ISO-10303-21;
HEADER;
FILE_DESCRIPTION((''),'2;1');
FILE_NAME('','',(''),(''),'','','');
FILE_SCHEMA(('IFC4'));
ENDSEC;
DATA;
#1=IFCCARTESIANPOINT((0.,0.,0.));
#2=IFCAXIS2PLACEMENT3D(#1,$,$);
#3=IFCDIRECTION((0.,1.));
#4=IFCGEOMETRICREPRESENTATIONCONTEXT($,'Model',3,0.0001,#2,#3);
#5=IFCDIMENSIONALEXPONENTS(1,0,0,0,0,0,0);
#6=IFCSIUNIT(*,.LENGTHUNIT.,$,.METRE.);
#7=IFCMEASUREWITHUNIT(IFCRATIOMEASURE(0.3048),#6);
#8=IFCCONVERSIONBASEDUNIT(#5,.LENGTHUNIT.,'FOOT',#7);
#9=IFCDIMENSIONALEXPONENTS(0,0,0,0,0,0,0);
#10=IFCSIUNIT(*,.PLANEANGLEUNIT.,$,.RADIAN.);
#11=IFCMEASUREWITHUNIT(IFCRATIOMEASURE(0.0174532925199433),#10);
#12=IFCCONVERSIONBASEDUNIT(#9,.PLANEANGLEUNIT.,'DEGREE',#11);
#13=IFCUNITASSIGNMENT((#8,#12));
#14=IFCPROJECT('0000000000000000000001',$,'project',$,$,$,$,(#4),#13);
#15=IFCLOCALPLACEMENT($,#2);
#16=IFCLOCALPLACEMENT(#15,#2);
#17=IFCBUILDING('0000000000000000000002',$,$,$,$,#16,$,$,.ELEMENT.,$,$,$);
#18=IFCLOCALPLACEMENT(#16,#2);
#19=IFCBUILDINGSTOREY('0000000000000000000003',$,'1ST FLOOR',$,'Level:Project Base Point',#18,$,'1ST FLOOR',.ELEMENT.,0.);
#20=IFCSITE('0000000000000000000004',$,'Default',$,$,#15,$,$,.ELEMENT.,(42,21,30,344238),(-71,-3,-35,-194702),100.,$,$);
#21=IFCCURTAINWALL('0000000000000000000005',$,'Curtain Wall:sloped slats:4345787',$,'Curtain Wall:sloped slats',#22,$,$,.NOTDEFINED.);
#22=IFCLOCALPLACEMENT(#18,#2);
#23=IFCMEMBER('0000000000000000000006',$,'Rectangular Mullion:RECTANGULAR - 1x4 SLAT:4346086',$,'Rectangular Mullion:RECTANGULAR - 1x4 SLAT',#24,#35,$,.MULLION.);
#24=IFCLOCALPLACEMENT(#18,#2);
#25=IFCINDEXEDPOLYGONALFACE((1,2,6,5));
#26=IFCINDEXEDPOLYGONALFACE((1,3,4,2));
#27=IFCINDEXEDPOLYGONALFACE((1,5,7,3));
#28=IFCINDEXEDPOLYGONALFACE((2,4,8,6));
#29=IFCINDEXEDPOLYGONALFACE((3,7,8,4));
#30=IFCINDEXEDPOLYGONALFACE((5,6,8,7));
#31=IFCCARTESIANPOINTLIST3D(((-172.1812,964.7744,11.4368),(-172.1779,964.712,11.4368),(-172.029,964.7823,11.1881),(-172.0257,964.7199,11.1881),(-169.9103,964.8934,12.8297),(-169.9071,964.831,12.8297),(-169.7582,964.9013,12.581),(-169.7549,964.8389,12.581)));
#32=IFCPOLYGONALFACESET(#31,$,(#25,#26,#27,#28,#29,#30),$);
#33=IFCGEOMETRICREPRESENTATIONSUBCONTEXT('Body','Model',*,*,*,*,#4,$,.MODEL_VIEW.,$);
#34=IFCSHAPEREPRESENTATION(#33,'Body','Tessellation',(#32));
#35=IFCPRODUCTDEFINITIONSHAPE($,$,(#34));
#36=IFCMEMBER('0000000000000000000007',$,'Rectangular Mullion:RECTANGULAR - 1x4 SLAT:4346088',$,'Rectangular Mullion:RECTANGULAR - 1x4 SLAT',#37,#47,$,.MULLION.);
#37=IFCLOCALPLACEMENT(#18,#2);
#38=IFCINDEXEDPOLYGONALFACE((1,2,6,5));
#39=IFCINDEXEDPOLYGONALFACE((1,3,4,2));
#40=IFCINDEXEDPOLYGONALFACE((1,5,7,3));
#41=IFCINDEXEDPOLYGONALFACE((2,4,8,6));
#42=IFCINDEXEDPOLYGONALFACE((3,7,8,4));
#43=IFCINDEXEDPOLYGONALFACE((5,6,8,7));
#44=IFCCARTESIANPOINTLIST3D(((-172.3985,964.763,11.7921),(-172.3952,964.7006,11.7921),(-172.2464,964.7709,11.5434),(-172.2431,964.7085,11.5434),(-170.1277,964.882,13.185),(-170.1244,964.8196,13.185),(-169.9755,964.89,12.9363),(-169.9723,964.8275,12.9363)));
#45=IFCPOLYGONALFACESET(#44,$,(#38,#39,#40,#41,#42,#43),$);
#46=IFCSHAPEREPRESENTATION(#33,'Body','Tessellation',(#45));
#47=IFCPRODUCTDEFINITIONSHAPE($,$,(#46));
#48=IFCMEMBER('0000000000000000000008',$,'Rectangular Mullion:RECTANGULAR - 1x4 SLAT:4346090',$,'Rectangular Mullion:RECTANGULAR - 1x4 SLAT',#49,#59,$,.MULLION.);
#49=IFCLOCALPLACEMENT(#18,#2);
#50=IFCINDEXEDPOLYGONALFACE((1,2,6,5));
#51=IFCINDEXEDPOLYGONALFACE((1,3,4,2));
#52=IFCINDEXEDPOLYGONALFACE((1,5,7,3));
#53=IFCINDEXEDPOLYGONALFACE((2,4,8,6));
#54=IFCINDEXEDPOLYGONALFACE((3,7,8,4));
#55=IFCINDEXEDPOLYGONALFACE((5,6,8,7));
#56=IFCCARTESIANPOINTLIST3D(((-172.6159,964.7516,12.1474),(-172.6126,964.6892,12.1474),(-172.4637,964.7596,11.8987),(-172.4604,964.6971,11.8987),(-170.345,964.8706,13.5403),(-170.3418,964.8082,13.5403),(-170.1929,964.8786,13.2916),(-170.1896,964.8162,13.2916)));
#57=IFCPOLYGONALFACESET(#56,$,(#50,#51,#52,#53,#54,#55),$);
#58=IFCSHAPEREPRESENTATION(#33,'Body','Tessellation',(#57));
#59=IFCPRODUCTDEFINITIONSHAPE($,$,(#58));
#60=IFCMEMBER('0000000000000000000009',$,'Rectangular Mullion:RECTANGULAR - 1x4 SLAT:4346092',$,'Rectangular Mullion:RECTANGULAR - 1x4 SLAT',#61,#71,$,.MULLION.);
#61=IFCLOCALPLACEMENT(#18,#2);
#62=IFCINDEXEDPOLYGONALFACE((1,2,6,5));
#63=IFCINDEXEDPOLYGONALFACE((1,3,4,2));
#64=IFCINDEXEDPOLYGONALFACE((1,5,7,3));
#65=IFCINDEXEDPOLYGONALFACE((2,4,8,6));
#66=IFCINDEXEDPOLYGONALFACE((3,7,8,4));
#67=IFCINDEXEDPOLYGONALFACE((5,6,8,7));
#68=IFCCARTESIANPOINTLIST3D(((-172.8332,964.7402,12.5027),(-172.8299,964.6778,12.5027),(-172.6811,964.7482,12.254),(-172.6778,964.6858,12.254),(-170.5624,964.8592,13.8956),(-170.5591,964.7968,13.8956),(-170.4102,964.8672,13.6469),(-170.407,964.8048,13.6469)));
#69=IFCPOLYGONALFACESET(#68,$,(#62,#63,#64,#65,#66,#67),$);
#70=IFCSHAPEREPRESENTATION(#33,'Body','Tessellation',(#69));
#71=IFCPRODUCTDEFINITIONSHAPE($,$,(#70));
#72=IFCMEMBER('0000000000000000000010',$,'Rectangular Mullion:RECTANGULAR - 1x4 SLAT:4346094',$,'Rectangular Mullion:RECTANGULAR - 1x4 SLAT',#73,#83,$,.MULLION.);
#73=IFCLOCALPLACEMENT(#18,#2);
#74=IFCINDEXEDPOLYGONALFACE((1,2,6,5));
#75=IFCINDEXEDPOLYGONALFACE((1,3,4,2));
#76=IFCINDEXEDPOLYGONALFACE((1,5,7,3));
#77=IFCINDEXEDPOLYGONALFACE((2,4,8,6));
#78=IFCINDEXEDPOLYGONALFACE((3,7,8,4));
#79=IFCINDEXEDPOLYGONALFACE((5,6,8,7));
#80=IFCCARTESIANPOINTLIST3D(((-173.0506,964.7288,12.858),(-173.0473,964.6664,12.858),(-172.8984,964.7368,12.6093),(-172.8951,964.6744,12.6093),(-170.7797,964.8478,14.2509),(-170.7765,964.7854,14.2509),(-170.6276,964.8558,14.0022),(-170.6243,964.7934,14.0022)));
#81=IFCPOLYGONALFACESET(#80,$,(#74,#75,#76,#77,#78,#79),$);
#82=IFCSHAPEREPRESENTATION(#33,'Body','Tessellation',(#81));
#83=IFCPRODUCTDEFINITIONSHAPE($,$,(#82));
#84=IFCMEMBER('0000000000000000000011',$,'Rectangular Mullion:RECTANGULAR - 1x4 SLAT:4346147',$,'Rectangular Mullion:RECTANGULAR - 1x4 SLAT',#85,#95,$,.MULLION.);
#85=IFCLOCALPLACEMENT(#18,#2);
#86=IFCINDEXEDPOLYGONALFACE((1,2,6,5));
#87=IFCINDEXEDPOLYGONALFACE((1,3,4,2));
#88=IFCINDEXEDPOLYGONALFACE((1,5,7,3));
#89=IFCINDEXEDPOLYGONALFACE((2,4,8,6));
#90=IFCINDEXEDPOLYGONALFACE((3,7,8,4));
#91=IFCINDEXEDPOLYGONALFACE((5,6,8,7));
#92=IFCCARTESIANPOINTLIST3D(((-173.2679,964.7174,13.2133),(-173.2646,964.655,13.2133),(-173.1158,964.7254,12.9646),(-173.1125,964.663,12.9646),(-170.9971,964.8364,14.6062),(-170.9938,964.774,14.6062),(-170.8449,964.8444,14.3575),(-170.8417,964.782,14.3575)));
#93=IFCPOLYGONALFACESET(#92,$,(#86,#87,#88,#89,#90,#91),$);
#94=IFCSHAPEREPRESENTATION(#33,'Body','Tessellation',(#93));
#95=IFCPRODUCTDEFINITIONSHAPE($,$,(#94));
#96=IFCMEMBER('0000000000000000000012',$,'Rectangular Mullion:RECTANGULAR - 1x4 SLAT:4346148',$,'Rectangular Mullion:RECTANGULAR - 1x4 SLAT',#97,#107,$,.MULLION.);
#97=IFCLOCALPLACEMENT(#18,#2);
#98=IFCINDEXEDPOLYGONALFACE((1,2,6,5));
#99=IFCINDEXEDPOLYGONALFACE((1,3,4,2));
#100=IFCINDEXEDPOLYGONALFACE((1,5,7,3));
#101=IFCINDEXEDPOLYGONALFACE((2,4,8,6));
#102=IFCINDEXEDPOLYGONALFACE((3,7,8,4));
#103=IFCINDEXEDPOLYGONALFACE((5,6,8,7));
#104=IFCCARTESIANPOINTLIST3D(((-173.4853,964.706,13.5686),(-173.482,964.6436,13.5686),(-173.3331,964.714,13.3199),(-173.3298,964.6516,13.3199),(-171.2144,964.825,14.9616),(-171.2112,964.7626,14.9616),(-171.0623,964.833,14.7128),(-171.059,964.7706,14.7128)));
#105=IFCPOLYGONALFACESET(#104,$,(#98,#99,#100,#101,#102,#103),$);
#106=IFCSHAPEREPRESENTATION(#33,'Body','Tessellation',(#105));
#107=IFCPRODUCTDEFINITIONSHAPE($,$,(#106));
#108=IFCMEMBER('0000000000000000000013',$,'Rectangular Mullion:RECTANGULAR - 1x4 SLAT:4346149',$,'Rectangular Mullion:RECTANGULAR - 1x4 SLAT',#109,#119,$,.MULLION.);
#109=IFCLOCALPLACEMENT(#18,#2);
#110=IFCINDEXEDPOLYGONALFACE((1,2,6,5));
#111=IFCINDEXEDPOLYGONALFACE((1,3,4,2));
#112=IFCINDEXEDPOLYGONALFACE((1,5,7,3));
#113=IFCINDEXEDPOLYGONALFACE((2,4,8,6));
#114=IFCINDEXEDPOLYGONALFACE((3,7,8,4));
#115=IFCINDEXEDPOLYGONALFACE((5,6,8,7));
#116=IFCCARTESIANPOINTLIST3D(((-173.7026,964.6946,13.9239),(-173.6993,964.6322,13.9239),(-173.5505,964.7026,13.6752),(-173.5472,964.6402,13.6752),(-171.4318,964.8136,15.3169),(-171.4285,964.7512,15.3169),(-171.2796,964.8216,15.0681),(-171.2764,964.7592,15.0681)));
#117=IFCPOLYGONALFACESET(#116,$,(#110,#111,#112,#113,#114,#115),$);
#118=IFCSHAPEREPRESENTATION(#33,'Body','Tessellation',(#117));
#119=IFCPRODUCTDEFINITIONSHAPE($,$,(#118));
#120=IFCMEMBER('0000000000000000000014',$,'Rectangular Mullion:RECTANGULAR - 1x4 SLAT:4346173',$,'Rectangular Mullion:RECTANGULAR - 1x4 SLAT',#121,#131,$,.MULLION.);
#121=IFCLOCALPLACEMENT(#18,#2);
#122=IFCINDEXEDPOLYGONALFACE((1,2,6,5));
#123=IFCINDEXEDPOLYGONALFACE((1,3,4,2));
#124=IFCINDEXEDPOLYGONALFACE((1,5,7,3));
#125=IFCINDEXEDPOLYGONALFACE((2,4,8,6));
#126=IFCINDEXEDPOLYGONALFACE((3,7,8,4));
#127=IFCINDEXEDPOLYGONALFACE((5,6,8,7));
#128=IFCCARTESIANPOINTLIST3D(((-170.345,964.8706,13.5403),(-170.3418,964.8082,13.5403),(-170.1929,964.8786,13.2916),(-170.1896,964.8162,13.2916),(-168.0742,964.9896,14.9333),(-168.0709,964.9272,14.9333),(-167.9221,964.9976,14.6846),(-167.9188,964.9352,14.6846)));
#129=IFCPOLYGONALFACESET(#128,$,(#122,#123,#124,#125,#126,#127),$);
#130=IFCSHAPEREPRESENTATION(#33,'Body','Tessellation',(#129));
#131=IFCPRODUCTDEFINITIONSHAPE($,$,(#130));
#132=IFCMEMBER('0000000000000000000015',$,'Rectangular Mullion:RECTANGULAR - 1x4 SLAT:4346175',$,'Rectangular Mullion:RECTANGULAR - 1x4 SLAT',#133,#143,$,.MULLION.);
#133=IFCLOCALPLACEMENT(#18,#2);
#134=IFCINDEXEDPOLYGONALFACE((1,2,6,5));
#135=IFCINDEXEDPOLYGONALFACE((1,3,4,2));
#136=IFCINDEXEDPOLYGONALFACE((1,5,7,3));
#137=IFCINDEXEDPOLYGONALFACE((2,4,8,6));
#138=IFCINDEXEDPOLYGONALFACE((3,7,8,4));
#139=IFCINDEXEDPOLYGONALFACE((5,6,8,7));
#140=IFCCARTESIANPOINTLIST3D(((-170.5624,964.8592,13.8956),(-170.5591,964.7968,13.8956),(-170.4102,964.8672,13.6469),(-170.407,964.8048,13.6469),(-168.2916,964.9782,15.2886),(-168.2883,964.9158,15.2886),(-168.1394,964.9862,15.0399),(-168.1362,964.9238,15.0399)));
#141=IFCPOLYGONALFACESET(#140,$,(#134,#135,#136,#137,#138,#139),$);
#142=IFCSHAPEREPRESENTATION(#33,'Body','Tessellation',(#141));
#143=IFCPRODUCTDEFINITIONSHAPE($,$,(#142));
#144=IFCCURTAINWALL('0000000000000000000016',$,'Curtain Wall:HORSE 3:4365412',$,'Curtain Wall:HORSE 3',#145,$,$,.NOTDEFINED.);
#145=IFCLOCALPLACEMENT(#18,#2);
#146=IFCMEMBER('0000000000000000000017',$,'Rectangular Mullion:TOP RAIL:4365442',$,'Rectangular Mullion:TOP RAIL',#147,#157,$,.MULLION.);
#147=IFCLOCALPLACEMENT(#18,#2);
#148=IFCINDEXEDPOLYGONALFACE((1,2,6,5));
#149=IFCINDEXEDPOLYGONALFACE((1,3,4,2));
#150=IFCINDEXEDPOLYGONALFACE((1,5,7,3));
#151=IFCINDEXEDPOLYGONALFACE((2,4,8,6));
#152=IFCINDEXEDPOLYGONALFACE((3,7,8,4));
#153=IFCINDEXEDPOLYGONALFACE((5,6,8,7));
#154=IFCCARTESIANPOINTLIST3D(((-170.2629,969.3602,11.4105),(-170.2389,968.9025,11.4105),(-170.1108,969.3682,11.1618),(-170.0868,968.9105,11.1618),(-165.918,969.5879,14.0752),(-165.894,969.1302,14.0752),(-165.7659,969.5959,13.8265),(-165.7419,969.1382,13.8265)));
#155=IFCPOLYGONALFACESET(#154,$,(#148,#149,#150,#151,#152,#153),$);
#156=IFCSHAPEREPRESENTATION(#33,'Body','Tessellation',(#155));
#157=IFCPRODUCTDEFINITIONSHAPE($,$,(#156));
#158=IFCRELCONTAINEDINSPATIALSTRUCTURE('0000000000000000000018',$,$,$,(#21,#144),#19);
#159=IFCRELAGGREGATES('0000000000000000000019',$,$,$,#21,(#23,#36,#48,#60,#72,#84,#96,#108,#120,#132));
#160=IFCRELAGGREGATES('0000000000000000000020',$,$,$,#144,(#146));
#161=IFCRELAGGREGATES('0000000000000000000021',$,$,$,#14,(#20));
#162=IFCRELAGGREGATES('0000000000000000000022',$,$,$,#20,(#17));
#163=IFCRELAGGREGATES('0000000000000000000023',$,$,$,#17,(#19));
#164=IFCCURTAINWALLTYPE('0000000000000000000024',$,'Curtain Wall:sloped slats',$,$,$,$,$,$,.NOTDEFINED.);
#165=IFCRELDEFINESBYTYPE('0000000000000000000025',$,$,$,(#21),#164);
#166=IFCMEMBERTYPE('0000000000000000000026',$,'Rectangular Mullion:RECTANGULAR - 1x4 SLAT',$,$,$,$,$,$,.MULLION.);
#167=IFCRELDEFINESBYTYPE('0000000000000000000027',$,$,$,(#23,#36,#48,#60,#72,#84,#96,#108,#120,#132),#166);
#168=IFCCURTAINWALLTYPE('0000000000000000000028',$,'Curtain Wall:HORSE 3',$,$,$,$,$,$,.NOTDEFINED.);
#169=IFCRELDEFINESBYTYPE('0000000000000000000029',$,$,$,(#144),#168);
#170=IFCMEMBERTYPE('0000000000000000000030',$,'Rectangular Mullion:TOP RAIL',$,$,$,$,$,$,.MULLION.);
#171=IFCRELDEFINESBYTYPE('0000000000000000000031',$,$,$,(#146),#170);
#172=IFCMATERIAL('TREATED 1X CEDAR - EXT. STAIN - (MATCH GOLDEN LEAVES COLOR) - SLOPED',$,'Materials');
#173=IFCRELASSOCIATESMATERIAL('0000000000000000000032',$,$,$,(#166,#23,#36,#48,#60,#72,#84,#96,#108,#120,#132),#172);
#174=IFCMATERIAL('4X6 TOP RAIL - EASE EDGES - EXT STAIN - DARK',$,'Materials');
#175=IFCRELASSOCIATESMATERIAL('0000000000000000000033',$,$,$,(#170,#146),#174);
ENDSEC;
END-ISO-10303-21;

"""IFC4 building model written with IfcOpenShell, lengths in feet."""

from ifc_helpers import new_model, entity, si_unit, converted_unit, direction, frame, frame_2d, origin, origin_2d_with_axis, place, context, subcontext, project, spatial, rectangle, extrude, source, transform, mapped, material, material_profile, profile_set, profile_usage, type_object, type_shapes, element, aggregate, save


model = new_model("IFC4")

# Units and contexts
model_context = context("Model", 3, precision=0.0001, world=origin(), true_north=direction((0.0, 1.0)))
body_context = subcontext(model_context, "Body", "Model", "MODEL_VIEW")
ifc_project = project(units=[converted_unit("LENGTHUNIT", "FOOT", entity("IfcRatioMeasure", 0.3048), si_unit("LENGTHUNIT", "METRE"), dimensions=[1, 0, 0, 0, 0, 0, 0]), converted_unit("PLANEANGLEUNIT", "DEGREE", entity("IfcRatioMeasure", 0.0174532925199433), si_unit("PLANEANGLEUNIT", "RADIAN"), dimensions=[0, 0, 0, 0, 0, 0, 0])], contexts=[model_context])

# Site, building, storey
site_placement = place(None, origin())
site = spatial("IfcSite", under=ifc_project, at=site_placement, Name="Default", CompositionType="ELEMENT", RefLatitude=(42, 21, 30, 344238), RefLongitude=(-71, -3, -35, -194702), RefElevation=100.0)
building_placement = place(site_placement, origin())
building = spatial("IfcBuilding", under=site, at=building_placement, CompositionType="ELEMENT")
storey_placement = place(building_placement, origin())
storey = spatial("IfcBuildingStorey", under=building, at=storey_placement, Name="1ST FLOOR", ObjectType="Level:Project Base Point", LongName="1ST FLOOR", CompositionType="ELEMENT", Elevation=0.0)

# Curtain wall, members
curtain_wall_type_1 = type_object("IfcCurtainWallType", Name="Curtain Wall:sloped slats", PredefinedType="NOTDEFINED")
curtain_wall_1_placement = place(storey_placement, origin())
curtain_wall_1 = element("IfcCurtainWall", 1, at=curtain_wall_1_placement, inside=storey, type_object=curtain_wall_type_1, Name="Curtain Wall:sloped slats:4345787", ObjectType="Curtain Wall:sloped slats", PredefinedType="NOTDEFINED")
ifc_material_1 = material(Name="TREATED 1X CEDAR - EXT. STAIN - (MATCH GOLDEN LEAVES COLOR) - SLOPED", Category="Materials")
ifc_material_profile_1 = material_profile(ifc_material_1, rectangle(XDim=0.0625, YDim=0.2917, at=frame_2d((0.0, 0.0), x_axis=(1.0, 0.0))), Name="RECTANGULAR - 1x4 SLAT")
ifc_profile_set_1 = profile_set([ifc_material_profile_1], Name="RECTANGULAR - 1x4 SLAT")
ifc_profile_usage_1 = profile_usage(ifc_profile_set_1)
member_type_1 = type_object("IfcMemberType", Name="Rectangular Mullion:RECTANGULAR - 1x4 SLAT", PredefinedType="MULLION", material=ifc_profile_set_1)
shared_shape_1 = source(origin(), body_context, "Body", "SweptSolid", [
    extrude(rectangle(XDim=0.0625, YDim=0.2917, at=frame_2d((0.0, 0.0), x_axis=(1.0, 0.0))), frame((0.0, 0.0, -2.6667), z_axis=(0.0, 0.0, 1.0), x_axis=(0.0, -1.0, 0.0)), (0.0, 0.0, 1.0), 2.6667),
])
type_shapes(member_type_1, [shared_shape_1])
member_1_placement = place(storey_placement, frame((-172.1035, 964.7471, 11.3124), z_axis=(-0.851559, -0.044628, -0.522356), x_axis=(-0.52164, -0.027338, 0.852727)))
member_1 = element("IfcMember", 2, at=member_1_placement, type_object=member_type_1, material=ifc_profile_usage_1, Name="Rectangular Mullion:RECTANGULAR - 1x4 SLAT:4346086", ObjectType="Rectangular Mullion:RECTANGULAR - 1x4 SLAT", PredefinedType="MULLION", context=body_context, shape_type="MappedRepresentation", body=[
    mapped(shared_shape_1, transform((0.0, 0.0, 0.0), scale=1.0)),
])
ifc_profile_usage_2 = profile_usage(ifc_profile_set_1)
member_2_placement = place(storey_placement, frame((-172.3208, 964.7358, 11.6677), z_axis=(-0.851559, -0.044628, -0.522356), x_axis=(-0.52164, -0.027338, 0.852727)))
member_2 = element("IfcMember", 3, at=member_2_placement, type_object=member_type_1, material=ifc_profile_usage_2, Name="Rectangular Mullion:RECTANGULAR - 1x4 SLAT:4346088", ObjectType="Rectangular Mullion:RECTANGULAR - 1x4 SLAT", PredefinedType="MULLION", context=body_context, shape_type="MappedRepresentation", body=[
    mapped(shared_shape_1, transform((0.0, 0.0, 0.0), scale=1.0)),
])
ifc_profile_usage_3 = profile_usage(ifc_profile_set_1)
member_3_placement = place(storey_placement, frame((-172.5382, 964.7244, 12.023), z_axis=(-0.851559, -0.044628, -0.522356), x_axis=(-0.52164, -0.027338, 0.852727)))
member_3 = element("IfcMember", 4, at=member_3_placement, type_object=member_type_1, material=ifc_profile_usage_3, Name="Rectangular Mullion:RECTANGULAR - 1x4 SLAT:4346090", ObjectType="Rectangular Mullion:RECTANGULAR - 1x4 SLAT", PredefinedType="MULLION", context=body_context, shape_type="MappedRepresentation", body=[
    mapped(shared_shape_1, transform((0.0, 0.0, 0.0), scale=1.0)),
])
ifc_profile_usage_4 = profile_usage(ifc_profile_set_1)
member_4_placement = place(storey_placement, frame((-172.7555, 964.713, 12.3783), z_axis=(-0.851559, -0.044628, -0.522356), x_axis=(-0.52164, -0.027338, 0.852727)))
member_4 = element("IfcMember", 5, at=member_4_placement, type_object=member_type_1, material=ifc_profile_usage_4, Name="Rectangular Mullion:RECTANGULAR - 1x4 SLAT:4346092", ObjectType="Rectangular Mullion:RECTANGULAR - 1x4 SLAT", PredefinedType="MULLION", context=body_context, shape_type="MappedRepresentation", body=[
    mapped(shared_shape_1, transform((0.0, 0.0, 0.0), scale=1.0)),
])
ifc_profile_usage_5 = profile_usage(ifc_profile_set_1)
member_5_placement = place(storey_placement, frame((-172.9729, 964.7016, 12.7336), z_axis=(-0.851559, -0.044628, -0.522356), x_axis=(-0.52164, -0.027338, 0.852727)))
member_5 = element("IfcMember", 6, at=member_5_placement, type_object=member_type_1, material=ifc_profile_usage_5, Name="Rectangular Mullion:RECTANGULAR - 1x4 SLAT:4346094", ObjectType="Rectangular Mullion:RECTANGULAR - 1x4 SLAT", PredefinedType="MULLION", context=body_context, shape_type="MappedRepresentation", body=[
    mapped(shared_shape_1, transform((0.0, 0.0, 0.0), scale=1.0)),
])
ifc_profile_usage_6 = profile_usage(ifc_profile_set_1)
member_6_placement = place(storey_placement, frame((-173.1902, 964.6902, 13.0889), z_axis=(-0.851559, -0.044628, -0.522356), x_axis=(-0.52164, -0.027338, 0.852727)))
member_6 = element("IfcMember", 7, at=member_6_placement, type_object=member_type_1, material=ifc_profile_usage_6, Name="Rectangular Mullion:RECTANGULAR - 1x4 SLAT:4346147", ObjectType="Rectangular Mullion:RECTANGULAR - 1x4 SLAT", PredefinedType="MULLION", context=body_context, shape_type="MappedRepresentation", body=[
    mapped(shared_shape_1, transform((0.0, 0.0, 0.0), scale=1.0)),
])
ifc_profile_usage_7 = profile_usage(ifc_profile_set_1)
member_7_placement = place(storey_placement, frame((-173.4076, 964.6788, 13.4442), z_axis=(-0.851559, -0.044628, -0.522356), x_axis=(-0.52164, -0.027338, 0.852727)))
member_7 = element("IfcMember", 8, at=member_7_placement, type_object=member_type_1, material=ifc_profile_usage_7, Name="Rectangular Mullion:RECTANGULAR - 1x4 SLAT:4346148", ObjectType="Rectangular Mullion:RECTANGULAR - 1x4 SLAT", PredefinedType="MULLION", context=body_context, shape_type="MappedRepresentation", body=[
    mapped(shared_shape_1, transform((0.0, 0.0, 0.0), scale=1.0)),
])
ifc_profile_usage_8 = profile_usage(ifc_profile_set_1)
member_8_placement = place(storey_placement, frame((-173.6249, 964.6674, 13.7995), z_axis=(-0.851559, -0.044628, -0.522356), x_axis=(-0.52164, -0.027338, 0.852727)))
member_8 = element("IfcMember", 9, at=member_8_placement, type_object=member_type_1, material=ifc_profile_usage_8, Name="Rectangular Mullion:RECTANGULAR - 1x4 SLAT:4346149", ObjectType="Rectangular Mullion:RECTANGULAR - 1x4 SLAT", PredefinedType="MULLION", context=body_context, shape_type="MappedRepresentation", body=[
    mapped(shared_shape_1, transform((0.0, 0.0, 0.0), scale=1.0)),
])
ifc_profile_usage_9 = profile_usage(ifc_profile_set_1)
member_9_placement = place(storey_placement, frame((-170.2673, 964.8434, 13.416), z_axis=(-0.851559, -0.044628, -0.522356), x_axis=(-0.52164, -0.027338, 0.852727)))
member_9 = element("IfcMember", 10, at=member_9_placement, type_object=member_type_1, material=ifc_profile_usage_9, Name="Rectangular Mullion:RECTANGULAR - 1x4 SLAT:4346173", ObjectType="Rectangular Mullion:RECTANGULAR - 1x4 SLAT", PredefinedType="MULLION", context=body_context, shape_type="MappedRepresentation", body=[
    mapped(shared_shape_1, transform((0.0, 0.0, 0.0), scale=1.0)),
])
ifc_profile_usage_10 = profile_usage(ifc_profile_set_1)
member_10_placement = place(storey_placement, frame((-170.4847, 964.832, 13.7713), z_axis=(-0.851559, -0.044628, -0.522356), x_axis=(-0.52164, -0.027338, 0.852727)))
member_10 = element("IfcMember", 11, at=member_10_placement, type_object=member_type_1, material=ifc_profile_usage_10, Name="Rectangular Mullion:RECTANGULAR - 1x4 SLAT:4346175", ObjectType="Rectangular Mullion:RECTANGULAR - 1x4 SLAT", PredefinedType="MULLION", context=body_context, shape_type="MappedRepresentation", body=[
    mapped(shared_shape_1, transform((0.0, 0.0, 0.0), scale=1.0)),
])
aggregate(curtain_wall_1, [member_1, member_2, member_3, member_4, member_5, member_6, member_7, member_8, member_9, member_10])

# Curtain wall, member
curtain_wall_type_2 = type_object("IfcCurtainWallType", Name="Curtain Wall:HORSE 3", PredefinedType="NOTDEFINED")
curtain_wall_2_placement = place(storey_placement, origin())
curtain_wall_2 = element("IfcCurtainWall", 12, at=curtain_wall_2_placement, inside=storey, type_object=curtain_wall_type_2, Name="Curtain Wall:HORSE 3:4365412", ObjectType="Curtain Wall:HORSE 3", PredefinedType="NOTDEFINED")
ifc_material_2 = material(Name="4X6 TOP RAIL - EASE EDGES - EXT STAIN - DARK", Category="Materials")
ifc_material_profile_2 = material_profile(ifc_material_2, rectangle(XDim=0.4583, YDim=0.2917, at=origin_2d_with_axis()), Name="TOP RAIL")
ifc_profile_set_2 = profile_set([ifc_material_profile_2], Name="TOP RAIL")
ifc_profile_usage_11 = profile_usage(ifc_profile_set_2)
member_type_2 = type_object("IfcMemberType", Name="Rectangular Mullion:TOP RAIL", PredefinedType="MULLION", material=ifc_profile_set_2)
shared_shape_2 = source(origin(), body_context, "Body", "SweptSolid", [
    extrude(rectangle(XDim=0.4583, YDim=0.2917, at=frame_2d((0.0, 0.0), x_axis=(1.0, 0.0))), frame((-0.1458, 0.0625, -5.102), z_axis=(0.0, 0.0, 1.0), x_axis=(0.0, -1.0, 0.0)), (0.0, 0.0, 1.0), 5.102),
])
type_shapes(member_type_2, [shared_shape_2])
member_11_placement = place(storey_placement, frame((-170.2476, 969.0689, 11.4105), z_axis=(-0.851606, -0.044631, -0.522279), x_axis=(-0.521563, -0.027334, 0.852775)))
member_11 = element("IfcMember", 13, at=member_11_placement, type_object=member_type_2, material=ifc_profile_usage_11, Name="Rectangular Mullion:TOP RAIL:4365442", ObjectType="Rectangular Mullion:TOP RAIL", PredefinedType="MULLION", context=body_context, shape_type="MappedRepresentation", body=[
    mapped(shared_shape_2, transform((0.0, 0.0, 0.0), scale=1.0)),
])
aggregate(curtain_wall_2, [member_11])

save(model, "model.ifc")
